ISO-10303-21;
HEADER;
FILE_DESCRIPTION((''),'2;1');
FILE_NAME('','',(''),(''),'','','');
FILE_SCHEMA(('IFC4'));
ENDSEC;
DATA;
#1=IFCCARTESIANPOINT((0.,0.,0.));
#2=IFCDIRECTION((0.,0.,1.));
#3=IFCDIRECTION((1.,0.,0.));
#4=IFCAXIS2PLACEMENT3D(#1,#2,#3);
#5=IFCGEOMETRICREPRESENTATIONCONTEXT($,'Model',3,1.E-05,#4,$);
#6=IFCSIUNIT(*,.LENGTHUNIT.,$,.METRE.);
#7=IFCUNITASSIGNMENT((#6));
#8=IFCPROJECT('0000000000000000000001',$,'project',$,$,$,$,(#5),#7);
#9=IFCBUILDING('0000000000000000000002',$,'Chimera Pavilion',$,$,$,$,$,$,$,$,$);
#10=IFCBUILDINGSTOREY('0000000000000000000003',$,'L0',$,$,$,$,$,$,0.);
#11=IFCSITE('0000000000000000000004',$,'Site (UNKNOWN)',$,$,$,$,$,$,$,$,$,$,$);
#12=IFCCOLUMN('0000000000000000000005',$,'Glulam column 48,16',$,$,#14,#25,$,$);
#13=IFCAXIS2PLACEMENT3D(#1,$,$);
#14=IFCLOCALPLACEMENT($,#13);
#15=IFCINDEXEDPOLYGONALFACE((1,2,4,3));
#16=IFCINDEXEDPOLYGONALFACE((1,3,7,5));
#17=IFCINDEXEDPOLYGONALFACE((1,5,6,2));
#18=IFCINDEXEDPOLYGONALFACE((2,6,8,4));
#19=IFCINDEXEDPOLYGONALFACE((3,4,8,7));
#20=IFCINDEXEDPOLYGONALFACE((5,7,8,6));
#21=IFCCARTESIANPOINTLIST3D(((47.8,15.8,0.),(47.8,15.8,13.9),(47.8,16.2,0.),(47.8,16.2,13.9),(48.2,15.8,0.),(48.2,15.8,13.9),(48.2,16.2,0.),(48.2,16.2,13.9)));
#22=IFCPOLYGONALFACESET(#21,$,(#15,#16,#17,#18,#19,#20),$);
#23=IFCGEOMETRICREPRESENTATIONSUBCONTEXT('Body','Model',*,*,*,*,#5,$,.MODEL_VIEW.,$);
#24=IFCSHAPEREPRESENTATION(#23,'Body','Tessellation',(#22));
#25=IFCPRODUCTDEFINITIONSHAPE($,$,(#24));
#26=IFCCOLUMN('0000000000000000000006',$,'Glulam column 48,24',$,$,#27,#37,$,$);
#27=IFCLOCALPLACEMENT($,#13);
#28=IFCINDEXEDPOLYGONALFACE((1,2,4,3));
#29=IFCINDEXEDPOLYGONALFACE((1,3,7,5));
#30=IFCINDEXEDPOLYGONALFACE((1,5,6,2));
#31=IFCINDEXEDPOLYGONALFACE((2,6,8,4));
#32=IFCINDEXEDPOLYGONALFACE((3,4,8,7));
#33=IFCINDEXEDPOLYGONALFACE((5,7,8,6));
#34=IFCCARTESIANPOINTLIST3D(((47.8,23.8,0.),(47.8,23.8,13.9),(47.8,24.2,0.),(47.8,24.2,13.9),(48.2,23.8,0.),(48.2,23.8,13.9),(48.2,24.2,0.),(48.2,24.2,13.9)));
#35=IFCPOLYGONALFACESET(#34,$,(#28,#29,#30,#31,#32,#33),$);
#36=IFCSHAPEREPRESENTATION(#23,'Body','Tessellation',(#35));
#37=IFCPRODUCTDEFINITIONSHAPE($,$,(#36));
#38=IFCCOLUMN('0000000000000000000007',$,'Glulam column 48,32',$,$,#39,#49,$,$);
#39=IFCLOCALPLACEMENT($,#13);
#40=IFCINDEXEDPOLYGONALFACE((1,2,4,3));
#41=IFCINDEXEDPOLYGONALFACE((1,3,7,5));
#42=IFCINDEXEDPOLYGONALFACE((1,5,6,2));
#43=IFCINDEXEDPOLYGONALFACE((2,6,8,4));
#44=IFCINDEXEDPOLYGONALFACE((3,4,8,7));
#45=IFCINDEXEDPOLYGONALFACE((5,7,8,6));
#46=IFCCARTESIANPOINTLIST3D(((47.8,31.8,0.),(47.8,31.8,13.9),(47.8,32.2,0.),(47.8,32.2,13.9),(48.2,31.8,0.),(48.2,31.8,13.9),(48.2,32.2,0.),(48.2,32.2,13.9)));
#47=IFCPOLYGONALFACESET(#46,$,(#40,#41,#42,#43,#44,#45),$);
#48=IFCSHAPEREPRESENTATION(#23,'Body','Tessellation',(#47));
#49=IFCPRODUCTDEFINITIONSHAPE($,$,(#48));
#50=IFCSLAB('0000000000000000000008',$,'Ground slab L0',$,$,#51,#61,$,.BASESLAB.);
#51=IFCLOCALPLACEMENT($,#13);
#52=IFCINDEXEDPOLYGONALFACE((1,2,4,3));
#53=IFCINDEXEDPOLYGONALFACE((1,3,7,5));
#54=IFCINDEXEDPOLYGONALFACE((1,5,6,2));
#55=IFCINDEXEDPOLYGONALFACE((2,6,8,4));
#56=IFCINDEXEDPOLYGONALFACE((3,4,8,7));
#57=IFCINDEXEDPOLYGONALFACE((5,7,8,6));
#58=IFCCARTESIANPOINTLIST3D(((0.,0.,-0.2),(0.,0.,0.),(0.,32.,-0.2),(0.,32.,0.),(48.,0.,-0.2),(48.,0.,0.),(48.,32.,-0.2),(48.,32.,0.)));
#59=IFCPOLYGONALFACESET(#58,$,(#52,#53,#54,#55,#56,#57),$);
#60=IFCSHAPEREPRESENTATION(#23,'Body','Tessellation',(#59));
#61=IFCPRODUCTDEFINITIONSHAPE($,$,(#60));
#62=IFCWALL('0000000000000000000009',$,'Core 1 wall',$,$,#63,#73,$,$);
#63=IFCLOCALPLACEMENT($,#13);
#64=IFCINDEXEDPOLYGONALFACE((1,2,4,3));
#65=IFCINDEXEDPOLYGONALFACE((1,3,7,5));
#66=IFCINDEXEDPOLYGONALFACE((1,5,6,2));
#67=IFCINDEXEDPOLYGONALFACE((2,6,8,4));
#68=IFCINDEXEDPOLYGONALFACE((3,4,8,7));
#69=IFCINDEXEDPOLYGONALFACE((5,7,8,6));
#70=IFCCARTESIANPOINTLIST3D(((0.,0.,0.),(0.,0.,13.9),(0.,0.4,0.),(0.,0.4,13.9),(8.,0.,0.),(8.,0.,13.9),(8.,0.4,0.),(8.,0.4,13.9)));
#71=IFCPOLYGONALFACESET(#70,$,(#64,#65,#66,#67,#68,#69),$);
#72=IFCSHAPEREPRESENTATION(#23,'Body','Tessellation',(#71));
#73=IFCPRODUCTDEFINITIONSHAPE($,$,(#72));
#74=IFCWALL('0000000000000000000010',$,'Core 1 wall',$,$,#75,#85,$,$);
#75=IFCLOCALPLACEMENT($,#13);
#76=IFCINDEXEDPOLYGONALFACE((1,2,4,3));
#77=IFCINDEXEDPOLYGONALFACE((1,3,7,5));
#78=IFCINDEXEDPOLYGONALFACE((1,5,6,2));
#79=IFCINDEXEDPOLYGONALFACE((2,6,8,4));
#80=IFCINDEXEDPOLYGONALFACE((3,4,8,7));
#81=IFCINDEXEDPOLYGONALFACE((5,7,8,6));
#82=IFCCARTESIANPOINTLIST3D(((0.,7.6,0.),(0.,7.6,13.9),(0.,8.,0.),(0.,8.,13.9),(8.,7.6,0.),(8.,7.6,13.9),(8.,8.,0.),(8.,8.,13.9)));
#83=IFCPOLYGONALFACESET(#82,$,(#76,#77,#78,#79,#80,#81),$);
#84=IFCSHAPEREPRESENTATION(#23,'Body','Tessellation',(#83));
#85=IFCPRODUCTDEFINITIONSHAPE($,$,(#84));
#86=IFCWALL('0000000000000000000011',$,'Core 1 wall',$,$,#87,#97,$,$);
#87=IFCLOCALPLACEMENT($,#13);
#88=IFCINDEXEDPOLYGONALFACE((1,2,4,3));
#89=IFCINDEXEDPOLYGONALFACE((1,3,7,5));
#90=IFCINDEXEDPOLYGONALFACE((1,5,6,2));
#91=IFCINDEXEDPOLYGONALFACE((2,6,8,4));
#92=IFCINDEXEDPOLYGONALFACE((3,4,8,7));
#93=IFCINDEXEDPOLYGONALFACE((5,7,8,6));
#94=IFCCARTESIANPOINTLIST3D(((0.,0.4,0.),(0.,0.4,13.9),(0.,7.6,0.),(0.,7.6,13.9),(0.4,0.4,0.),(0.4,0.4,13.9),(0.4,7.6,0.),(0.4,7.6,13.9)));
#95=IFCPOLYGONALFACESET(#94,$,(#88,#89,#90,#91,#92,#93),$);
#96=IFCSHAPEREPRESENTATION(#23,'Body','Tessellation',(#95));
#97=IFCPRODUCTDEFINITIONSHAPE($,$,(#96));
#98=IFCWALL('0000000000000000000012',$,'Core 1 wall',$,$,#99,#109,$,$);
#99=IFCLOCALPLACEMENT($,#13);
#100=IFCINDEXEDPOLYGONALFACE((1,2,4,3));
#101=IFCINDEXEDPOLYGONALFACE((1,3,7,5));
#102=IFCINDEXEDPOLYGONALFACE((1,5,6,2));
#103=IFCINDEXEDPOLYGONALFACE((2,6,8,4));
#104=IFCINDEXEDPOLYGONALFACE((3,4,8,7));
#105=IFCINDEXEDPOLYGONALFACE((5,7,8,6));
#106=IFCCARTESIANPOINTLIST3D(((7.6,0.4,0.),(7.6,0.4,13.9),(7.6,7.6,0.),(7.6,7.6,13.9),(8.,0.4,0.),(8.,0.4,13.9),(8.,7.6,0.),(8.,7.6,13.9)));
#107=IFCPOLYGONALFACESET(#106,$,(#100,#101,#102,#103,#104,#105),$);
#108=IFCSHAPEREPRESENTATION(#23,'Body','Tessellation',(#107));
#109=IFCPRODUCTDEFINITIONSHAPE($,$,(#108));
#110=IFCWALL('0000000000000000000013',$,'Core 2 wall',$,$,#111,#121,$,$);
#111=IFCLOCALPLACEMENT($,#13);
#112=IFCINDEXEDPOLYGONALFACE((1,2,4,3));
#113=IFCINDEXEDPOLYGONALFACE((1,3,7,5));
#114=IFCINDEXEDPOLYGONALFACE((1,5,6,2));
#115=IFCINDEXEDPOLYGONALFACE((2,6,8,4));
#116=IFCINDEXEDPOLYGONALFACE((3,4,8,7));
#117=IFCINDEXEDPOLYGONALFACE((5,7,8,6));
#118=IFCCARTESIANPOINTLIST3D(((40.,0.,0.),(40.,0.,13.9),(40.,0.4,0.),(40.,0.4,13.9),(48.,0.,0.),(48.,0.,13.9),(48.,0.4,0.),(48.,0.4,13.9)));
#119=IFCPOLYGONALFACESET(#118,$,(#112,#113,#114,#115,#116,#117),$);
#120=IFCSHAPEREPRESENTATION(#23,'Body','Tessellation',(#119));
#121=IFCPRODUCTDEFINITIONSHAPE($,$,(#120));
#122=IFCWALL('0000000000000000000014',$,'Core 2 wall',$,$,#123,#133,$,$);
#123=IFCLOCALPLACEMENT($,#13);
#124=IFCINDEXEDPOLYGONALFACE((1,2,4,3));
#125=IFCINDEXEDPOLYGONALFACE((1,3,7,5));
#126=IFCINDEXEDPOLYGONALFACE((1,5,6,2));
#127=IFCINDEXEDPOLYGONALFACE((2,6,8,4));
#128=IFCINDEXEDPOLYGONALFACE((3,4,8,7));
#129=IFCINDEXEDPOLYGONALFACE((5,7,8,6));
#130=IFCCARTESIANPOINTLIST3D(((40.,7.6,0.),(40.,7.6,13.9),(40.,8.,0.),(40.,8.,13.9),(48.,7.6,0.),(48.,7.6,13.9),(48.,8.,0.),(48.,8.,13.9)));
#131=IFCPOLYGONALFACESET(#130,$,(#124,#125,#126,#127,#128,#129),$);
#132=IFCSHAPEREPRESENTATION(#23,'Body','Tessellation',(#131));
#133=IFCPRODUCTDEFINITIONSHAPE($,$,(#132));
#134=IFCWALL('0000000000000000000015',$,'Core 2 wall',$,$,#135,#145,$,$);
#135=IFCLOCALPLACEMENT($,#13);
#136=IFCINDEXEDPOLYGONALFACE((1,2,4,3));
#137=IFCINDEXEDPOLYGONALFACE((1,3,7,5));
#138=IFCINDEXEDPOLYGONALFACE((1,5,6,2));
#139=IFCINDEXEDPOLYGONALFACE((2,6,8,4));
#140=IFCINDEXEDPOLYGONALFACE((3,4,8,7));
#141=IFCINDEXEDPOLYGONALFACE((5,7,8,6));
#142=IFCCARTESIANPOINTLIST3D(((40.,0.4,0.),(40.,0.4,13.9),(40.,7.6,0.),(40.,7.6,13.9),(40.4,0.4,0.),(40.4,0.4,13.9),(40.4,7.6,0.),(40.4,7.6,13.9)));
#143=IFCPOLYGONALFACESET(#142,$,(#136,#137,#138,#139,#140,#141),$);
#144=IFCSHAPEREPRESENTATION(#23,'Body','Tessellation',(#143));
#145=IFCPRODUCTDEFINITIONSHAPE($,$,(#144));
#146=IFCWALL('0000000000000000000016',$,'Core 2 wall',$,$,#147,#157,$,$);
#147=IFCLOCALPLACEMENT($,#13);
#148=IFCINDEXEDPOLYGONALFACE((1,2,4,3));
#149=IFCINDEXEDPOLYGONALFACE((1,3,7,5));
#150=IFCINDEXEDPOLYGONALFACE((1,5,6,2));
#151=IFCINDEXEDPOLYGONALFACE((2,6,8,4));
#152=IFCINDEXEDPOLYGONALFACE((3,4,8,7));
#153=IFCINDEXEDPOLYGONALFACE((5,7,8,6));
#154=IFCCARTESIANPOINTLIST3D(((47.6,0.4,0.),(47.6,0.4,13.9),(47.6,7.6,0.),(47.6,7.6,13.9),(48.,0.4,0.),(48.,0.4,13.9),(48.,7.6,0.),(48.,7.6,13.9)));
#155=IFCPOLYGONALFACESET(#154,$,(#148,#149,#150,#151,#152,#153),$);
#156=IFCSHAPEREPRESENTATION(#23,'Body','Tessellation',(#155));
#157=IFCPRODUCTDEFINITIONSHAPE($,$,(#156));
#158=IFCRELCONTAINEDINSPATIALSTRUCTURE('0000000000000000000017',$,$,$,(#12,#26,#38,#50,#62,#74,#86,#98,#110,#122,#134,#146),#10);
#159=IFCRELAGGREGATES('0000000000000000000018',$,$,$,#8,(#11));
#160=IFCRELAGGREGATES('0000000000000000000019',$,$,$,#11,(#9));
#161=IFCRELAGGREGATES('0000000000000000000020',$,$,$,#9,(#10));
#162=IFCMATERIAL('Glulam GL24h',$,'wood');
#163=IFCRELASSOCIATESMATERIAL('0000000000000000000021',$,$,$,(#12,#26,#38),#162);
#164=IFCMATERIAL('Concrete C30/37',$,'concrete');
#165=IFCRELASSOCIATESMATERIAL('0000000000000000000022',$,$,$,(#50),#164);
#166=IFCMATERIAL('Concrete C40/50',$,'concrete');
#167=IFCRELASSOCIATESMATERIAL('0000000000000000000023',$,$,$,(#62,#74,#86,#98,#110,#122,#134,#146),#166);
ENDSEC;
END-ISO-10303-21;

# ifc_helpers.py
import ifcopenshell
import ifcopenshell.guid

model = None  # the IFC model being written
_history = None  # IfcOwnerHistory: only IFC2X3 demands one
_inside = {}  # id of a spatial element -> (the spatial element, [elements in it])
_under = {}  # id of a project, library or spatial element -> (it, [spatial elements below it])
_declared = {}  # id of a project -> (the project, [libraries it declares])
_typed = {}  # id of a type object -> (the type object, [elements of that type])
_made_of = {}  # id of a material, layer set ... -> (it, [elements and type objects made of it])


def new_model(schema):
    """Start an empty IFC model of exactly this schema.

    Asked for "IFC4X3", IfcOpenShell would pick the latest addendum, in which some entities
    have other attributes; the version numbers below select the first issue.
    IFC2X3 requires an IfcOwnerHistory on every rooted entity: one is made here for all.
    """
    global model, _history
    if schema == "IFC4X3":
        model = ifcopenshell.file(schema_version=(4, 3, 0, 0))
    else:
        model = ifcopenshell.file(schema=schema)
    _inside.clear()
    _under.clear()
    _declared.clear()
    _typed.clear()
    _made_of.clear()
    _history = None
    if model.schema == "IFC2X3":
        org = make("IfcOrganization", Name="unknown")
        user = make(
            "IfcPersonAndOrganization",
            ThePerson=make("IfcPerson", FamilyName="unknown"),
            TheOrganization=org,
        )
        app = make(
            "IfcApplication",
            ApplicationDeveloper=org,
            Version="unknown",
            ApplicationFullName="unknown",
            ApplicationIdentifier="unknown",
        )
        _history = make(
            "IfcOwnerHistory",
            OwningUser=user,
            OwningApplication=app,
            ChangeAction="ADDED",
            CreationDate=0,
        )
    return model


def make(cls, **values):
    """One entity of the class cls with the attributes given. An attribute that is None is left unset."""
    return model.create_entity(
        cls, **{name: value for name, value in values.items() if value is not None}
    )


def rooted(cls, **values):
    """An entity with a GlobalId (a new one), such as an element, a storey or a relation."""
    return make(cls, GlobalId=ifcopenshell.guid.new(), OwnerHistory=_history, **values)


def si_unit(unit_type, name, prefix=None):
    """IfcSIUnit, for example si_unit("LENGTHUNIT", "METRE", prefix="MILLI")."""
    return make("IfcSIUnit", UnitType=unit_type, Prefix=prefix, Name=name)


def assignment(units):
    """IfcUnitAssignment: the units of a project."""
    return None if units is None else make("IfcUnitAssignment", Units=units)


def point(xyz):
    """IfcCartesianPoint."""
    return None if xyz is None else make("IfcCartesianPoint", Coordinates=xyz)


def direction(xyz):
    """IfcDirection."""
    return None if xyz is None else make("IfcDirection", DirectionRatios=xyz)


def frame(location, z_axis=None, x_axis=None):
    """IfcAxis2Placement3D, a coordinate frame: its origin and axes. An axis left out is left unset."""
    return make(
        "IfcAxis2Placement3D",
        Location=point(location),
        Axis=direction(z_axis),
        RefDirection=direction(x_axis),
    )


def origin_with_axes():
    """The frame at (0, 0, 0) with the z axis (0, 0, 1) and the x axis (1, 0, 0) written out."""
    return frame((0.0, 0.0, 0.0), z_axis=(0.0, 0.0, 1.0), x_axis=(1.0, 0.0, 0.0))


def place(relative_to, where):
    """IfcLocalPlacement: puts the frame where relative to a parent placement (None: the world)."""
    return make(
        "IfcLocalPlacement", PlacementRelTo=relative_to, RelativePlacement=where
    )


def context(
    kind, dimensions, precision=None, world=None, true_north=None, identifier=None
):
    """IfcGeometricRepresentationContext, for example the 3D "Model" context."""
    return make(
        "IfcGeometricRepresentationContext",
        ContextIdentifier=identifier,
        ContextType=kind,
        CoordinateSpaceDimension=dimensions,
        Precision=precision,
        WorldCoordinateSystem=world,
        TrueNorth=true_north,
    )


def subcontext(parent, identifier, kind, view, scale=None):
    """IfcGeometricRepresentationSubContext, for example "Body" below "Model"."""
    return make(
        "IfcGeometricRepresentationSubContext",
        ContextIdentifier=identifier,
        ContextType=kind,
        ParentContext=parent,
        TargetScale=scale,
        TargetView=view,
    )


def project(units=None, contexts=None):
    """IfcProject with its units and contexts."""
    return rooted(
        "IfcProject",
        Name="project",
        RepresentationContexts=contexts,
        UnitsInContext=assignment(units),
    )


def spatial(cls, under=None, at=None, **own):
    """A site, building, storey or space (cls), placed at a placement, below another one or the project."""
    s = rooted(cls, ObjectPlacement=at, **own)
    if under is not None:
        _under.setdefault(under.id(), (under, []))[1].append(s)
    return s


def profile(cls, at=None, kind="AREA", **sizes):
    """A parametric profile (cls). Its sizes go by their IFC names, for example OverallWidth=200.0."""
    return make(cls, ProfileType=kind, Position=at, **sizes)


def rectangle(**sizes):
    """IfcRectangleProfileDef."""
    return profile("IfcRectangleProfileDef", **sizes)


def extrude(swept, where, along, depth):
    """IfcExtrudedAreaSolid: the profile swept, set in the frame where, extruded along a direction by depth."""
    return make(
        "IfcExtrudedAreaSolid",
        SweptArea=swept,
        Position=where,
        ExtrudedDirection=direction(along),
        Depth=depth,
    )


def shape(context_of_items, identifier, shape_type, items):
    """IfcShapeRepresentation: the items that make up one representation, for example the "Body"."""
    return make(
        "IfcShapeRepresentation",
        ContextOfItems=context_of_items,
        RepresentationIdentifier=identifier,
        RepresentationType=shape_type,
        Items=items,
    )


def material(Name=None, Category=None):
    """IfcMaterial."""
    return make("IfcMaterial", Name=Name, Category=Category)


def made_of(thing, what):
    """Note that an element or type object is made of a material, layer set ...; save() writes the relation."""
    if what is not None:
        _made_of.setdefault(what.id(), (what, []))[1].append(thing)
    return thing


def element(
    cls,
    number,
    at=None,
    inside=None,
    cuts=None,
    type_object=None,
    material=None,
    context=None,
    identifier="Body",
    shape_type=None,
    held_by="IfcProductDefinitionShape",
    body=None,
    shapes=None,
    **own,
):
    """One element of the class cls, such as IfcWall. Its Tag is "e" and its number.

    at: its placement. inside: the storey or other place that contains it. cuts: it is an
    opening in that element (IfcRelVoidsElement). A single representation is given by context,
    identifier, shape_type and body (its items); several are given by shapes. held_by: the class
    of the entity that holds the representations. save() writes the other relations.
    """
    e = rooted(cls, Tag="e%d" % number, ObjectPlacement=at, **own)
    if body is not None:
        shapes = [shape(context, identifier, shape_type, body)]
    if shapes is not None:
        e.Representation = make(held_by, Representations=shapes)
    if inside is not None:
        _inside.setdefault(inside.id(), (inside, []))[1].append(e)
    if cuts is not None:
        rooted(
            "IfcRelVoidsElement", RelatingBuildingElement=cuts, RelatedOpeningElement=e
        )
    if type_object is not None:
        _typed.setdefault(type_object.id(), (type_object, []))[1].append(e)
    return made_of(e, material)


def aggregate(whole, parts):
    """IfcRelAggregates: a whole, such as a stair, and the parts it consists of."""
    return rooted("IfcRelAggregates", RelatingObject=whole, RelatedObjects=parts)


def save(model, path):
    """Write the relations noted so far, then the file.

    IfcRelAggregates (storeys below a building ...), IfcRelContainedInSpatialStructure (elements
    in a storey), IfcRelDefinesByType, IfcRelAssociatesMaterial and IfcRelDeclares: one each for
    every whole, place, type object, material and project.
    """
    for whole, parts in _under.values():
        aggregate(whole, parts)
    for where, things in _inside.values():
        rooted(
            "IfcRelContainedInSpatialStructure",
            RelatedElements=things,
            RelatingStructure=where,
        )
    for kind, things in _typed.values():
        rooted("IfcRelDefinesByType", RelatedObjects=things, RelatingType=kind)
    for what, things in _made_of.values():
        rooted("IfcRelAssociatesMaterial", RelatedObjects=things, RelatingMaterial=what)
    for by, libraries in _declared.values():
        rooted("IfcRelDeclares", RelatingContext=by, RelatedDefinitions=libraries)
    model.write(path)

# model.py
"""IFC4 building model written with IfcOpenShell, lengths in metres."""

from ifc_helpers import new_model, si_unit, frame, origin_with_axes, place, context, subcontext, project, spatial, rectangle, extrude, material, element, save


model = new_model("IFC4")

# Units and contexts
model_context = context("Model", 3, precision=1e-05, world=origin_with_axes())
body_context = subcontext(model_context, "Body", "Model", "MODEL_VIEW")
ifc_project = project(units=[si_unit("LENGTHUNIT", "METRE")], contexts=[model_context])

# Site, building, storey
site = spatial("IfcSite", under=ifc_project, Name="Site (UNKNOWN)")
building = spatial("IfcBuilding", under=site, Name="Chimera Pavilion")
storey = spatial("IfcBuildingStorey", under=building, Name="L0", Elevation=0.0)

# Columns
ifc_material_1 = material(Name="Glulam GL24h", Category="wood")
for number, where, z_axis, x_axis, name in (
    (1, (48.0, 16.0, 0.0), (0.0, 0.0, 1.0), (1.0, 0.0, 0.0), "Glulam column 48,16"),
    (2, (48.0, 24.0, 0.0), (0.0, 0.0, 1.0), (1.0, 0.0, 0.0), "Glulam column 48,24"),
    (3, (48.0, 32.0, 0.0), (0.0, 0.0, 1.0), (1.0, 0.0, 0.0), "Glulam column 48,32"),
):
    element("IfcColumn", number, at=place(None, frame(where, z_axis=z_axis, x_axis=x_axis)), inside=storey, material=ifc_material_1, Name=name, context=body_context, shape_type="SweptSolid", body=[
        extrude(rectangle(XDim=0.4, YDim=0.4), origin_with_axes(), (0.0, 0.0, 1.0), 13.9),
    ])

# Slab
ifc_material_2 = material(Name="Concrete C30/37", Category="concrete")
slab_placement = place(None, frame((24.0, 16.0, -0.2), z_axis=(0.0, 0.0, 1.0), x_axis=(1.0, 0.0, 0.0)))
element("IfcSlab", 4, at=slab_placement, inside=storey, material=ifc_material_2, Name="Ground slab L0", PredefinedType="BASESLAB", context=body_context, shape_type="SweptSolid", body=[
    extrude(rectangle(XDim=48.0, YDim=32.0), origin_with_axes(), (0.0, 0.0, 1.0), 0.2),
])

# Walls
ifc_material_3 = material(Name="Concrete C40/50", Category="concrete")
for number, where, z_axis, x_axis, name in (
    (5, (4.0, 0.2, 0.0), (0.0, 0.0, 1.0), (1.0, 0.0, 0.0), "Core 1 wall"),
    (6, (4.0, 7.8, 0.0), (0.0, 0.0, 1.0), (1.0, 0.0, 0.0), "Core 1 wall"),
):
    element("IfcWall", number, at=place(None, frame(where, z_axis=z_axis, x_axis=x_axis)), inside=storey, material=ifc_material_3, Name=name, context=body_context, shape_type="SweptSolid", body=[
        extrude(rectangle(XDim=8.0, YDim=0.4), origin_with_axes(), (0.0, 0.0, 1.0), 13.9),
    ])
for number, where, z_axis, x_axis, name in (
    (7, (0.2, 4.0, 0.0), (0.0, 0.0, 1.0), (1.0, 0.0, 0.0), "Core 1 wall"),
    (8, (7.8, 4.0, 0.0), (0.0, 0.0, 1.0), (1.0, 0.0, 0.0), "Core 1 wall"),
):
    element("IfcWall", number, at=place(None, frame(where, z_axis=z_axis, x_axis=x_axis)), inside=storey, material=ifc_material_3, Name=name, context=body_context, shape_type="SweptSolid", body=[
        extrude(rectangle(XDim=0.4, YDim=7.2), origin_with_axes(), (0.0, 0.0, 1.0), 13.9),
    ])
for number, where, z_axis, x_axis, name in (
    (9, (44.0, 0.2, 0.0), (0.0, 0.0, 1.0), (1.0, 0.0, 0.0), "Core 2 wall"),
    (10, (44.0, 7.8, 0.0), (0.0, 0.0, 1.0), (1.0, 0.0, 0.0), "Core 2 wall"),
):
    element("IfcWall", number, at=place(None, frame(where, z_axis=z_axis, x_axis=x_axis)), inside=storey, material=ifc_material_3, Name=name, context=body_context, shape_type="SweptSolid", body=[
        extrude(rectangle(XDim=8.0, YDim=0.4), origin_with_axes(), (0.0, 0.0, 1.0), 13.9),
    ])
for number, where, z_axis, x_axis, name in (
    (11, (40.2, 4.0, 0.0), (0.0, 0.0, 1.0), (1.0, 0.0, 0.0), "Core 2 wall"),
    (12, (47.8, 4.0, 0.0), (0.0, 0.0, 1.0), (1.0, 0.0, 0.0), "Core 2 wall"),
):
    element("IfcWall", number, at=place(None, frame(where, z_axis=z_axis, x_axis=x_axis)), inside=storey, material=ifc_material_3, Name=name, context=body_context, shape_type="SweptSolid", body=[
        extrude(rectangle(XDim=0.4, YDim=7.2), origin_with_axes(), (0.0, 0.0, 1.0), 13.9),
    ])

save(model, "model.ifc")
